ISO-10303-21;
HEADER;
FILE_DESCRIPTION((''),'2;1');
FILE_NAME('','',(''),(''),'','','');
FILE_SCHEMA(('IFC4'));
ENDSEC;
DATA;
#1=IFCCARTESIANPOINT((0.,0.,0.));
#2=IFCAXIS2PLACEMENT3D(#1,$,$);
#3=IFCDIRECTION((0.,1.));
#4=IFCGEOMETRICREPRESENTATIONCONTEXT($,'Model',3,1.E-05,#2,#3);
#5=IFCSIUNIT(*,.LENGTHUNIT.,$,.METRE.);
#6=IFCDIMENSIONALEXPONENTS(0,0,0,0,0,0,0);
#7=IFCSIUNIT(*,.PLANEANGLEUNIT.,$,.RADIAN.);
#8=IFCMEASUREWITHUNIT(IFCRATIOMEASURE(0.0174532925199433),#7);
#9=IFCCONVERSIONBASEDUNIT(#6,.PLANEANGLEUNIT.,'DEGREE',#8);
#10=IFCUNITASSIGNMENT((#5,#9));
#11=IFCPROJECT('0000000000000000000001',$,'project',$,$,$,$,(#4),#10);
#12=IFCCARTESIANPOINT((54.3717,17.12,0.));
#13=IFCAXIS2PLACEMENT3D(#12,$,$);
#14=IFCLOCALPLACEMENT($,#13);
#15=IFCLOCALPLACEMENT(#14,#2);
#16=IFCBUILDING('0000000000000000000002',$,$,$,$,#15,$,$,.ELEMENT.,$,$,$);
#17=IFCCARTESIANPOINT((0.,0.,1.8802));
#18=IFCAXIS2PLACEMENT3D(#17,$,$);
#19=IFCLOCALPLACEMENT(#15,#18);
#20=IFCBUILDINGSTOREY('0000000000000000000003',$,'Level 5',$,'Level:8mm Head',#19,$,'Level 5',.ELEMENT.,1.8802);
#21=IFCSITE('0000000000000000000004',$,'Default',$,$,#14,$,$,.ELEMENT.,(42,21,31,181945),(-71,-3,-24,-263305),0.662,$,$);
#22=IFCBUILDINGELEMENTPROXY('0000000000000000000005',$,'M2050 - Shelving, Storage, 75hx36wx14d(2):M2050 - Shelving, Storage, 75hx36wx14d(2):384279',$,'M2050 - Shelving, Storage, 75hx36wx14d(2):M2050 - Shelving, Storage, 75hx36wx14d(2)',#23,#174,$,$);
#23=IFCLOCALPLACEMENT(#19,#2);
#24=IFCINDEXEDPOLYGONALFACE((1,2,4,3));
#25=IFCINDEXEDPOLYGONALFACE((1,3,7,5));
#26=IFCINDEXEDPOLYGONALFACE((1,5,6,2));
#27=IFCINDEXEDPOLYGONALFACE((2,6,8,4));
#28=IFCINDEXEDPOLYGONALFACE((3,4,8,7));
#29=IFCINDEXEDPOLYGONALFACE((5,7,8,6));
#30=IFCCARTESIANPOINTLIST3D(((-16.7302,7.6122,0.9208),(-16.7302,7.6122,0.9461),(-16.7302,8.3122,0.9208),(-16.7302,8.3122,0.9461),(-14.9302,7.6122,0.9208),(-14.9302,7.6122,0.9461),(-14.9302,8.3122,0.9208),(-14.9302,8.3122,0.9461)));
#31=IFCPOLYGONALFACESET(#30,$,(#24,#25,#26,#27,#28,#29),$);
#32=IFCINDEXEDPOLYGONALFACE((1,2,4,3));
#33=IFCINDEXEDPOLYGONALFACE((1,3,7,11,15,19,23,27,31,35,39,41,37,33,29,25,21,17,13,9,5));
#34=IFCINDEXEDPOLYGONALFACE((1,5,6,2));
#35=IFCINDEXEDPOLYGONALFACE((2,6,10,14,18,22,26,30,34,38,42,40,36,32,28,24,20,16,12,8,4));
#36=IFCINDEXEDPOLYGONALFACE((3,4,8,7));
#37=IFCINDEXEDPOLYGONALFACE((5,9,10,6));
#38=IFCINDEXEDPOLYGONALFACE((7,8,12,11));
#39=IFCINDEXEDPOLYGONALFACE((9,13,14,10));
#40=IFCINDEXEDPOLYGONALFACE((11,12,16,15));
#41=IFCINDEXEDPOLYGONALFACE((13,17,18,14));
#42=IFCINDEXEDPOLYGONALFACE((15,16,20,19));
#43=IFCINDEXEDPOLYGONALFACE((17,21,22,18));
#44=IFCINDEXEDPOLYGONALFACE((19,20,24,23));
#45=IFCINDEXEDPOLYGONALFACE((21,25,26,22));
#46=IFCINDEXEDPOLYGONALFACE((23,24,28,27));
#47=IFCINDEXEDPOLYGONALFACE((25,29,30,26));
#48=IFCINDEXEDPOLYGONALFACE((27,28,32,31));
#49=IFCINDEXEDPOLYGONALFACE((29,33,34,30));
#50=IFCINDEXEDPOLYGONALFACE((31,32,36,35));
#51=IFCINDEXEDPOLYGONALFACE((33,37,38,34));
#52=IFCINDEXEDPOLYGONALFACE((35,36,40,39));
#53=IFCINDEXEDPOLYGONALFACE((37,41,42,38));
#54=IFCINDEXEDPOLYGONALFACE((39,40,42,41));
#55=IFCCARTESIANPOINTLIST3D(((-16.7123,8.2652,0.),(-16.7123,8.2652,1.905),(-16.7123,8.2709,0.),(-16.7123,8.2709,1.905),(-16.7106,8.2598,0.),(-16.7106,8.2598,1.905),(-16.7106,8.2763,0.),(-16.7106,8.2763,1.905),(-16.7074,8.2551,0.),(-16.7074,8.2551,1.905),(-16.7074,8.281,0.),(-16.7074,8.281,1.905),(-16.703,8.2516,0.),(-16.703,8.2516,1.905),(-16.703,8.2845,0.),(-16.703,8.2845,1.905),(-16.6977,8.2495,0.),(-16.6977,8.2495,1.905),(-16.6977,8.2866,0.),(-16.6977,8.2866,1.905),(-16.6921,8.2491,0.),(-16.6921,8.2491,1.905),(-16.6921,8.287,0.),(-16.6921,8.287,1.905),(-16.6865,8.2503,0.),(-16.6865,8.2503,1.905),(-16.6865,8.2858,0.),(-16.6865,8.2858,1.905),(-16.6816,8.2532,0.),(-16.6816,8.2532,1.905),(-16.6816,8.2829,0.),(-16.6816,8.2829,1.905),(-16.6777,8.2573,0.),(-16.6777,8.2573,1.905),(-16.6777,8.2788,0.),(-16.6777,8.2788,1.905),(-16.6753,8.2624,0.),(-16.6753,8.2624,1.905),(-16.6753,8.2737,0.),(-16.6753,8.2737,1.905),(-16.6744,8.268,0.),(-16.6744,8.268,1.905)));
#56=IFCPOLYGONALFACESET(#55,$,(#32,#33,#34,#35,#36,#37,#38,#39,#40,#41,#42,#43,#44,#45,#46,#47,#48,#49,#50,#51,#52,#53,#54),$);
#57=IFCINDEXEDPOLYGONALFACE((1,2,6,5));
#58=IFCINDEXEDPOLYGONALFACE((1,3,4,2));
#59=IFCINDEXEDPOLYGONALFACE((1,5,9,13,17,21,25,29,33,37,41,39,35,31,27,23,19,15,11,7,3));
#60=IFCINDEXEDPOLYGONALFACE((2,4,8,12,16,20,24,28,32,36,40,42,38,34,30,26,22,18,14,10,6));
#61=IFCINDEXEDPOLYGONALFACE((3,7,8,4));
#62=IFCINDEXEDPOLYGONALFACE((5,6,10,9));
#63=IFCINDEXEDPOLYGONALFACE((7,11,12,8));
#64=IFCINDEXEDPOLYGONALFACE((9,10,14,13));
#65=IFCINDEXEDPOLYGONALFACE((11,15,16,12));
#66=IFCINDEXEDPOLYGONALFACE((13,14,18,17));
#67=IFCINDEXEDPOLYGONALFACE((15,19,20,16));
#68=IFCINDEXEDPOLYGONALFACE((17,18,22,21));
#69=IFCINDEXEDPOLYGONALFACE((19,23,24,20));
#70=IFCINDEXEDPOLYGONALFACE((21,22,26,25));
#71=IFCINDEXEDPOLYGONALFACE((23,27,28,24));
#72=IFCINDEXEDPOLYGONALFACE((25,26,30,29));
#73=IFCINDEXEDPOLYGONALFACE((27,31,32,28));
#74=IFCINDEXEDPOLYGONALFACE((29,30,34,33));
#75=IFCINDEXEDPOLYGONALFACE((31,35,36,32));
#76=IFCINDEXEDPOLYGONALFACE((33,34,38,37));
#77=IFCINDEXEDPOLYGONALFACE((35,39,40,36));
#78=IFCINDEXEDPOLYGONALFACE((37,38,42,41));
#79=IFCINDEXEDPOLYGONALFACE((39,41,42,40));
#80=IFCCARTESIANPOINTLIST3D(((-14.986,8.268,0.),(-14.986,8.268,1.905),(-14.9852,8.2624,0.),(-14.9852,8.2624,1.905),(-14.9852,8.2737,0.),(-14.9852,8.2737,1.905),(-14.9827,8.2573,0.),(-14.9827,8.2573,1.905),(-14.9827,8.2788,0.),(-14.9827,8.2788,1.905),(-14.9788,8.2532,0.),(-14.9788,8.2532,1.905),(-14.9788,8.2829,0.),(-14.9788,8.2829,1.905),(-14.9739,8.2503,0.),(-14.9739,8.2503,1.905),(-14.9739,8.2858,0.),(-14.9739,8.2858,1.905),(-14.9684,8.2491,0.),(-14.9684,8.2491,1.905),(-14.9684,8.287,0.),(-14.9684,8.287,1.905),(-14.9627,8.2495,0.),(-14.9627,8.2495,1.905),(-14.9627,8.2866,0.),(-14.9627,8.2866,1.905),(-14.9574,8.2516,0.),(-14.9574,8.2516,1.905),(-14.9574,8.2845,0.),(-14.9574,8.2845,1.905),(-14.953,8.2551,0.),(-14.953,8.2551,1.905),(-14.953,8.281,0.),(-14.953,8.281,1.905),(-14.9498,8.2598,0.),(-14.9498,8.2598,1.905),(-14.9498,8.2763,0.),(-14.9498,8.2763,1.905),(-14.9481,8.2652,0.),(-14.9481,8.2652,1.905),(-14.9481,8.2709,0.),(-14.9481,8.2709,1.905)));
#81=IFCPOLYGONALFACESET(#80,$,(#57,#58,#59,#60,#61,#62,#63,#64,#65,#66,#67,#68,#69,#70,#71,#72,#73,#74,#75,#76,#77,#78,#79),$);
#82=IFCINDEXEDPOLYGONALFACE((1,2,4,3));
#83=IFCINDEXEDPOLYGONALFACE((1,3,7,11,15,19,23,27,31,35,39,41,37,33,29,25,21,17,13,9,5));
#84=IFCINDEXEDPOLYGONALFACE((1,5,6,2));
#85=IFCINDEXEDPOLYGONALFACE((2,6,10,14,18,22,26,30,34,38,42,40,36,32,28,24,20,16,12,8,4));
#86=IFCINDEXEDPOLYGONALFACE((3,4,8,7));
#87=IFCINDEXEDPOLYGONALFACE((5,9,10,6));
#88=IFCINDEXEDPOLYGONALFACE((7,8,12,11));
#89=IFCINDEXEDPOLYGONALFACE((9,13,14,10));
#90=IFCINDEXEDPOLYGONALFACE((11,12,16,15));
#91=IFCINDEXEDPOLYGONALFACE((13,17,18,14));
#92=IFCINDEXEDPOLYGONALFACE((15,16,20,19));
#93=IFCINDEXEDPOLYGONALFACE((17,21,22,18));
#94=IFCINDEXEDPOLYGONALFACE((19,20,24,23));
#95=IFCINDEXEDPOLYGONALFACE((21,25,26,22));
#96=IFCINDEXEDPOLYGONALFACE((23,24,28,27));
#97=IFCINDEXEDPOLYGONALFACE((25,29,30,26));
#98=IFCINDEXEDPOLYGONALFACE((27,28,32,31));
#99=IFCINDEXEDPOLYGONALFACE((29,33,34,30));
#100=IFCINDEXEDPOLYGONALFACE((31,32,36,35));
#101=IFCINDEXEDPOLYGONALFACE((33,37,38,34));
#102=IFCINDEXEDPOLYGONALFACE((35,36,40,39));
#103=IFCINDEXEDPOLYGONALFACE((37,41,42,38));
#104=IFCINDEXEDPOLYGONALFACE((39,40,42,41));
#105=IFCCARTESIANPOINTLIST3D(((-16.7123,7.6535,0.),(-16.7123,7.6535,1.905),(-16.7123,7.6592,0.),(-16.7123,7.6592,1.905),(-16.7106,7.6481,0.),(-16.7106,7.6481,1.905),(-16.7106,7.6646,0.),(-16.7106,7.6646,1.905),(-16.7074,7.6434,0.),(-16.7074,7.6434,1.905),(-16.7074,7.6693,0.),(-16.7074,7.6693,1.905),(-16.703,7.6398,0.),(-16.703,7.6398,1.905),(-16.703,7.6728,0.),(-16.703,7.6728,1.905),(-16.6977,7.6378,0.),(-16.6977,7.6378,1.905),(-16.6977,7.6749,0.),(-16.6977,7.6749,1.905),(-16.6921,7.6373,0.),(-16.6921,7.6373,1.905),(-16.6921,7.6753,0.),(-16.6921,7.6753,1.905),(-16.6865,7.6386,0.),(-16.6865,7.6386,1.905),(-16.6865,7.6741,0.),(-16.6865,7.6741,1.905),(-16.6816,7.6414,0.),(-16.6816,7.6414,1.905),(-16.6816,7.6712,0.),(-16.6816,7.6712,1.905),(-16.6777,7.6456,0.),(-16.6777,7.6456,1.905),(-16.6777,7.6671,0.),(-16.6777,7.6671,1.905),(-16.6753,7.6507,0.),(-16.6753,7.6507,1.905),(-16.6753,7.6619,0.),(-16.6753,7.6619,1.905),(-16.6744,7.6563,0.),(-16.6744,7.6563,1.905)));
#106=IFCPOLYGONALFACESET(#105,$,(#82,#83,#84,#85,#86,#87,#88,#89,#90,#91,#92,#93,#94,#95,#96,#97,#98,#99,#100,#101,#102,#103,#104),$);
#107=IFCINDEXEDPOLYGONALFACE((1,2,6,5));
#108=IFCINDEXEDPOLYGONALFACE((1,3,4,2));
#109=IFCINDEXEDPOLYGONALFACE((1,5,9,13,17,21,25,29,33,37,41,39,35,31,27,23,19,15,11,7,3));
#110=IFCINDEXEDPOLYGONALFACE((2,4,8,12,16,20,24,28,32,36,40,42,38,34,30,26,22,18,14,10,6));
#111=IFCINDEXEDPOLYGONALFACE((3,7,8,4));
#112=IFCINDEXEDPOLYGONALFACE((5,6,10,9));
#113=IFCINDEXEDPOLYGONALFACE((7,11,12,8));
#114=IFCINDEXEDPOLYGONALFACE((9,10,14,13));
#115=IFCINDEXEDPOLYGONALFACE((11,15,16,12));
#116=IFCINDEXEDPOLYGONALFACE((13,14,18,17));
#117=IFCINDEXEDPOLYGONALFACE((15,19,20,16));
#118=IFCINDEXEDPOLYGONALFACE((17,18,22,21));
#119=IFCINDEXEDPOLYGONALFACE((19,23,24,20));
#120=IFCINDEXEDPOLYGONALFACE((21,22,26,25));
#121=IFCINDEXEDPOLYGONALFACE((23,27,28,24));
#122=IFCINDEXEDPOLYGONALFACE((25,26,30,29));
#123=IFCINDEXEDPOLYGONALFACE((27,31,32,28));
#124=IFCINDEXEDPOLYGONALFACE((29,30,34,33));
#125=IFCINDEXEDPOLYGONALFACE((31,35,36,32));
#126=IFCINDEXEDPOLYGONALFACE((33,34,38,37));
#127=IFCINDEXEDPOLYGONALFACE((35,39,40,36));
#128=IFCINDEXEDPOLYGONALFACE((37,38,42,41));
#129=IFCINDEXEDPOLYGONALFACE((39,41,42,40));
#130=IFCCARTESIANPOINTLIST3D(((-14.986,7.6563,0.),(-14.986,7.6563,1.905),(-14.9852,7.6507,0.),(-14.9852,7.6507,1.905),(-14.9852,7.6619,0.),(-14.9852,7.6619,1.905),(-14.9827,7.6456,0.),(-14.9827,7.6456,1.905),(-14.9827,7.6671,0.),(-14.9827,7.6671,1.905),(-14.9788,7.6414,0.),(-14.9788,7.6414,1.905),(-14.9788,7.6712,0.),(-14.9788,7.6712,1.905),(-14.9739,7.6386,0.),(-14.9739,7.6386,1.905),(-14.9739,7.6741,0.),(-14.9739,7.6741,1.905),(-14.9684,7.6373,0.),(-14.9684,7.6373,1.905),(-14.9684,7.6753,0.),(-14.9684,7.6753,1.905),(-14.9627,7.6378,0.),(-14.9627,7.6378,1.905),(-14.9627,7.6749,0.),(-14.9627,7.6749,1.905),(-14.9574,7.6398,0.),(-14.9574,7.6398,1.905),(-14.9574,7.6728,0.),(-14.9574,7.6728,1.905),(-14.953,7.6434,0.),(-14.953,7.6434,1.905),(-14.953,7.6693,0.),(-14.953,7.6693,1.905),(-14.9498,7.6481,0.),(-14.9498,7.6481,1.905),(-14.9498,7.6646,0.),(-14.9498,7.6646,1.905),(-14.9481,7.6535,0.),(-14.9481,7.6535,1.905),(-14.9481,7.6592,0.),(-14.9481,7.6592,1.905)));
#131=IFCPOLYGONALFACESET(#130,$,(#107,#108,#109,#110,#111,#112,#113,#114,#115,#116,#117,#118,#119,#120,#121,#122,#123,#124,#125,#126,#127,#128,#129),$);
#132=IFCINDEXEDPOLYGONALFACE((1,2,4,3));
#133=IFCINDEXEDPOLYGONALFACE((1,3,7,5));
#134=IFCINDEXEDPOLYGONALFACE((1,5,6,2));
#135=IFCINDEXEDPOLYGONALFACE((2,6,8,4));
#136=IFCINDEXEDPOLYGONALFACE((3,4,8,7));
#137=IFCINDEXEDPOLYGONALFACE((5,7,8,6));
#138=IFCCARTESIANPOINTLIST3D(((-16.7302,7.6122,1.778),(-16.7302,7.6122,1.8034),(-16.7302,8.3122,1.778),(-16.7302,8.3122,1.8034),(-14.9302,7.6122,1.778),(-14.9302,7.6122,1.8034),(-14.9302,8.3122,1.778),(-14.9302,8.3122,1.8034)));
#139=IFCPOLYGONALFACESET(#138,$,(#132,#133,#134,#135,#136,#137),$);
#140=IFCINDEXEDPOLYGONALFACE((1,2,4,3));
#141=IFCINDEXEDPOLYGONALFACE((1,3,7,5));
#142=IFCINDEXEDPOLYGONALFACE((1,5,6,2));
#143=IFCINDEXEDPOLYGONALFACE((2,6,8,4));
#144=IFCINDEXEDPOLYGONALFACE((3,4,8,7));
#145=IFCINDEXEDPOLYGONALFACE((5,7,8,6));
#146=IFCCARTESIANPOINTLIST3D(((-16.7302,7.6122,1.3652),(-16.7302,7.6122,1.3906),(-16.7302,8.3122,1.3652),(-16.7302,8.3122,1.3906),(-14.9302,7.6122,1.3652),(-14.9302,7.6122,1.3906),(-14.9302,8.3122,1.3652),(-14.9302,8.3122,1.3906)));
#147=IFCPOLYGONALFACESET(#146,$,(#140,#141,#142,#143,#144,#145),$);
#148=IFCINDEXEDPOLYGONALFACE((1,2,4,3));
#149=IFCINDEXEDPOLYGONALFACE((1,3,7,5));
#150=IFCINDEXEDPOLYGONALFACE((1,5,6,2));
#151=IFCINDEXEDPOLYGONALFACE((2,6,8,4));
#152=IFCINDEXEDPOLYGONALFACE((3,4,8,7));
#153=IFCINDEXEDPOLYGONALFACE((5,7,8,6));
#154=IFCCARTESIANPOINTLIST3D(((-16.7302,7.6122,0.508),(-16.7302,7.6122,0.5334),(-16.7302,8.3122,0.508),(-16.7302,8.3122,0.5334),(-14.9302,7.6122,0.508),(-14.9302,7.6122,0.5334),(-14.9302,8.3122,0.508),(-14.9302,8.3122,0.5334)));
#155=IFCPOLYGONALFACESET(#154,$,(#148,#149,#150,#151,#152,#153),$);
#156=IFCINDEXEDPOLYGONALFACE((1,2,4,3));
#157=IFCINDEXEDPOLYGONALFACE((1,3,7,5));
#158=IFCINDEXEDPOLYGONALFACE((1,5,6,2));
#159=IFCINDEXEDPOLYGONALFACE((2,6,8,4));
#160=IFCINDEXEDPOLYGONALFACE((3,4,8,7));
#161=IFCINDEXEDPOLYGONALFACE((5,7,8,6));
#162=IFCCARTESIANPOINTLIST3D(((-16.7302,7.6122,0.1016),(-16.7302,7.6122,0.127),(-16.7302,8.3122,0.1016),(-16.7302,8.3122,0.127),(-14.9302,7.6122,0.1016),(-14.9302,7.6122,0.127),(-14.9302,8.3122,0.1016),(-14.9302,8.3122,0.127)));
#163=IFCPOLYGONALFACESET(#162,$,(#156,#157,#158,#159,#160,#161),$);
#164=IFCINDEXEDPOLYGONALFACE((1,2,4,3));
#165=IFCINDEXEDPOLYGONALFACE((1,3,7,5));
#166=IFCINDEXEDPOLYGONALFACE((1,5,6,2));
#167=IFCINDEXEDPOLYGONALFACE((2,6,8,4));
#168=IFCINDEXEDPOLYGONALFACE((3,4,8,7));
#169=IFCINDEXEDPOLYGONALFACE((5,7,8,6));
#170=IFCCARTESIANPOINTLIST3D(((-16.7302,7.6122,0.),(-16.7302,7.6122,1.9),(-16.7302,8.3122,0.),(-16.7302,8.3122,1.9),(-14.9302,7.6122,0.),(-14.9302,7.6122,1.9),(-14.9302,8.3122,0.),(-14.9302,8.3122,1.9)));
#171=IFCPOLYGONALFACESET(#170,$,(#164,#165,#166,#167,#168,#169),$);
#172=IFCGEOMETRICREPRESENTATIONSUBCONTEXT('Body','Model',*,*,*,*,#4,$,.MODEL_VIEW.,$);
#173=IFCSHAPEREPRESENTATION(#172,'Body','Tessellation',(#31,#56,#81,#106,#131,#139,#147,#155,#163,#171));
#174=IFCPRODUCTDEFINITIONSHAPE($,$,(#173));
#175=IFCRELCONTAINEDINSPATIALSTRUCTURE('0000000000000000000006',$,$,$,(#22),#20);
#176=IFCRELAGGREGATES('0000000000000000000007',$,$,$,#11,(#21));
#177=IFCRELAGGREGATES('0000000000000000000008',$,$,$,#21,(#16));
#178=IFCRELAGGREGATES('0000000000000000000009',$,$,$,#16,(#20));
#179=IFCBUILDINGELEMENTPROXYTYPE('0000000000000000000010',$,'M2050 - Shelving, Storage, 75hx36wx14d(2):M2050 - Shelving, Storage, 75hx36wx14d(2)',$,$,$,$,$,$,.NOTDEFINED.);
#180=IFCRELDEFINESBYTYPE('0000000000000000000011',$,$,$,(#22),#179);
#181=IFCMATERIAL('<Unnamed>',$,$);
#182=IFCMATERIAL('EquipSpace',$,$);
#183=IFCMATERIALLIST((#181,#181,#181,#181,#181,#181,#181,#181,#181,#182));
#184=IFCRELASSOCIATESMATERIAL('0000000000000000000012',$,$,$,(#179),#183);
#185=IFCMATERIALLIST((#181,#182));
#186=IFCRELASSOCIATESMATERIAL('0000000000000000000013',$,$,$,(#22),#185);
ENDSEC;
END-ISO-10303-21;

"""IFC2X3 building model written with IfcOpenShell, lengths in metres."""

from ifc_helpers import new_model, entity, si_unit, converted_unit, direction, frame, frame_2d, origin, origin_2d_with_axis, place, context, subcontext, project, spatial, rectangle, circle, extrude, source, transform, mapped, material, material_list, type_object, type_shapes, element, save


model = new_model("IFC2X3")

# Units and contexts
model_context = context("Model", 3, precision=1e-05, world=origin(), true_north=direction((0.0, 1.0)))
body_context = subcontext(model_context, "Body", "Model", "MODEL_VIEW")
ifc_project = project(units=[si_unit("LENGTHUNIT", "METRE"), converted_unit("PLANEANGLEUNIT", "DEGREE", entity("IfcRatioMeasure", 0.0174532925199433), si_unit("PLANEANGLEUNIT", "RADIAN"), dimensions=[0, 0, 0, 0, 0, 0, 0])], contexts=[model_context])

# Site, building, storey
site_placement = place(None, frame((54.3717, 17.12, 0.0)))
site = spatial("IfcSite", under=ifc_project, at=site_placement, Name="Default", CompositionType="ELEMENT", RefLatitude=(42, 21, 31, 181945), RefLongitude=(-71, -3, -24, -263305), RefElevation=0.662)
building_placement = place(site_placement, origin())
building = spatial("IfcBuilding", under=site, at=building_placement, CompositionType="ELEMENT")
storey_placement = place(building_placement, frame((0.0, 0.0, 1.8802)))
storey = spatial("IfcBuildingStorey", under=building, at=storey_placement, Name="Level 5", ObjectType="Level:8mm Head", LongName="Level 5", CompositionType="ELEMENT", Elevation=1.8802)

# Building element proxy
ifc_material_1 = material(Name="<Unnamed>")
ifc_material_2 = material(Name="EquipSpace")
ifc_material_list_1 = material_list([ifc_material_1, ifc_material_1, ifc_material_1, ifc_material_1, ifc_material_1, ifc_material_1, ifc_material_1, ifc_material_1, ifc_material_1, ifc_material_2])
building_element_proxy_type = type_object("IfcBuildingElementProxyType", Name="M2050 - Shelving, Storage, 75hx36wx14d(2):M2050 - Shelving, Storage, 75hx36wx14d(2)", PredefinedType="NOTDEFINED", material=ifc_material_list_1)
shared_shape = source(origin(), body_context, "Body", "SweptSolid", [
    extrude(rectangle(XDim=1.8, YDim=0.7, at=origin_2d_with_axis()), frame((0.0, 0.0, 0.9207), z_axis=(0.0, 0.0, 1.0), x_axis=(-1.0, 0.0, 0.0)), (0.0, 0.0, 1.0), 0.0254),
    extrude(circle(Radius=0.0191, at=origin_2d_with_axis()), frame((0.8633, -0.3059, 0.0), z_axis=(0.0, 0.0, 1.0), x_axis=(-1.0, 0.0, 0.0)), (0.0, 0.0, 1.0), 1.905),
    extrude(circle(Radius=0.0191, at=origin_2d_with_axis()), frame((-0.8633, -0.3059, 0.0)), (0.0, 0.0, 1.0), 1.905),
    extrude(circle(Radius=0.0191, at=origin_2d_with_axis()), frame((0.8633, 0.3059, 0.0), z_axis=(0.0, 0.0, 1.0), x_axis=(-1.0, 0.0, 0.0)), (0.0, 0.0, 1.0), 1.905),
    extrude(circle(Radius=0.0191, at=origin_2d_with_axis()), frame((-0.8633, 0.3059, 0.0)), (0.0, 0.0, 1.0), 1.905),
    extrude(rectangle(XDim=1.8, YDim=0.7, at=origin_2d_with_axis()), frame((0.0, 0.0, 1.778), z_axis=(0.0, 0.0, 1.0), x_axis=(-1.0, 0.0, 0.0)), (0.0, 0.0, 1.0), 0.0254),
    extrude(rectangle(XDim=1.8, YDim=0.7, at=origin_2d_with_axis()), frame((0.0, 0.0, 1.3653), z_axis=(0.0, 0.0, 1.0), x_axis=(-1.0, 0.0, 0.0)), (0.0, 0.0, 1.0), 0.0254),
    extrude(rectangle(XDim=1.8, YDim=0.7, at=origin_2d_with_axis()), frame((0.0, 0.0, 0.508), z_axis=(0.0, 0.0, 1.0), x_axis=(-1.0, 0.0, 0.0)), (0.0, 0.0, 1.0), 0.0254),
    extrude(rectangle(XDim=1.8, YDim=0.7, at=origin_2d_with_axis()), frame((0.0, 0.0, 0.1016), z_axis=(0.0, 0.0, 1.0), x_axis=(-1.0, 0.0, 0.0)), (0.0, 0.0, 1.0), 0.0254),
    extrude(rectangle(XDim=0.7, YDim=1.8, at=frame_2d((0.0, 0.18), x_axis=(1.0, 0.0))), frame((-0.18, 0.0, 0.0), z_axis=(0.0, 0.0, 1.0), x_axis=(0.0, -1.0, 0.0)), (0.0, 0.0, 1.0), 1.9),
])
type_shapes(building_element_proxy_type, [shared_shape])
ifc_material_list_2 = material_list([ifc_material_1, ifc_material_2])
proxy_1_placement = place(storey_placement, frame((-15.8302, 7.9622, 0.0), z_axis=(0.0, 0.0, 1.0), x_axis=(-1.0, 0.0, 0.0)))
element("IfcBuildingElementProxy", 1, at=proxy_1_placement, inside=storey, type_object=building_element_proxy_type, material=ifc_material_list_2, Name="M2050 - Shelving, Storage, 75hx36wx14d(2):M2050 - Shelving, Storage, 75hx36wx14d(2):384279", ObjectType="M2050 - Shelving, Storage, 75hx36wx14d(2):M2050 - Shelving, Storage, 75hx36wx14d(2)", context=body_context, shape_type="MappedRepresentation", body=[
    mapped(shared_shape, transform((0.0, 0.0, 0.0), scale=1.0)),
])

save(model, "model.ifc")
